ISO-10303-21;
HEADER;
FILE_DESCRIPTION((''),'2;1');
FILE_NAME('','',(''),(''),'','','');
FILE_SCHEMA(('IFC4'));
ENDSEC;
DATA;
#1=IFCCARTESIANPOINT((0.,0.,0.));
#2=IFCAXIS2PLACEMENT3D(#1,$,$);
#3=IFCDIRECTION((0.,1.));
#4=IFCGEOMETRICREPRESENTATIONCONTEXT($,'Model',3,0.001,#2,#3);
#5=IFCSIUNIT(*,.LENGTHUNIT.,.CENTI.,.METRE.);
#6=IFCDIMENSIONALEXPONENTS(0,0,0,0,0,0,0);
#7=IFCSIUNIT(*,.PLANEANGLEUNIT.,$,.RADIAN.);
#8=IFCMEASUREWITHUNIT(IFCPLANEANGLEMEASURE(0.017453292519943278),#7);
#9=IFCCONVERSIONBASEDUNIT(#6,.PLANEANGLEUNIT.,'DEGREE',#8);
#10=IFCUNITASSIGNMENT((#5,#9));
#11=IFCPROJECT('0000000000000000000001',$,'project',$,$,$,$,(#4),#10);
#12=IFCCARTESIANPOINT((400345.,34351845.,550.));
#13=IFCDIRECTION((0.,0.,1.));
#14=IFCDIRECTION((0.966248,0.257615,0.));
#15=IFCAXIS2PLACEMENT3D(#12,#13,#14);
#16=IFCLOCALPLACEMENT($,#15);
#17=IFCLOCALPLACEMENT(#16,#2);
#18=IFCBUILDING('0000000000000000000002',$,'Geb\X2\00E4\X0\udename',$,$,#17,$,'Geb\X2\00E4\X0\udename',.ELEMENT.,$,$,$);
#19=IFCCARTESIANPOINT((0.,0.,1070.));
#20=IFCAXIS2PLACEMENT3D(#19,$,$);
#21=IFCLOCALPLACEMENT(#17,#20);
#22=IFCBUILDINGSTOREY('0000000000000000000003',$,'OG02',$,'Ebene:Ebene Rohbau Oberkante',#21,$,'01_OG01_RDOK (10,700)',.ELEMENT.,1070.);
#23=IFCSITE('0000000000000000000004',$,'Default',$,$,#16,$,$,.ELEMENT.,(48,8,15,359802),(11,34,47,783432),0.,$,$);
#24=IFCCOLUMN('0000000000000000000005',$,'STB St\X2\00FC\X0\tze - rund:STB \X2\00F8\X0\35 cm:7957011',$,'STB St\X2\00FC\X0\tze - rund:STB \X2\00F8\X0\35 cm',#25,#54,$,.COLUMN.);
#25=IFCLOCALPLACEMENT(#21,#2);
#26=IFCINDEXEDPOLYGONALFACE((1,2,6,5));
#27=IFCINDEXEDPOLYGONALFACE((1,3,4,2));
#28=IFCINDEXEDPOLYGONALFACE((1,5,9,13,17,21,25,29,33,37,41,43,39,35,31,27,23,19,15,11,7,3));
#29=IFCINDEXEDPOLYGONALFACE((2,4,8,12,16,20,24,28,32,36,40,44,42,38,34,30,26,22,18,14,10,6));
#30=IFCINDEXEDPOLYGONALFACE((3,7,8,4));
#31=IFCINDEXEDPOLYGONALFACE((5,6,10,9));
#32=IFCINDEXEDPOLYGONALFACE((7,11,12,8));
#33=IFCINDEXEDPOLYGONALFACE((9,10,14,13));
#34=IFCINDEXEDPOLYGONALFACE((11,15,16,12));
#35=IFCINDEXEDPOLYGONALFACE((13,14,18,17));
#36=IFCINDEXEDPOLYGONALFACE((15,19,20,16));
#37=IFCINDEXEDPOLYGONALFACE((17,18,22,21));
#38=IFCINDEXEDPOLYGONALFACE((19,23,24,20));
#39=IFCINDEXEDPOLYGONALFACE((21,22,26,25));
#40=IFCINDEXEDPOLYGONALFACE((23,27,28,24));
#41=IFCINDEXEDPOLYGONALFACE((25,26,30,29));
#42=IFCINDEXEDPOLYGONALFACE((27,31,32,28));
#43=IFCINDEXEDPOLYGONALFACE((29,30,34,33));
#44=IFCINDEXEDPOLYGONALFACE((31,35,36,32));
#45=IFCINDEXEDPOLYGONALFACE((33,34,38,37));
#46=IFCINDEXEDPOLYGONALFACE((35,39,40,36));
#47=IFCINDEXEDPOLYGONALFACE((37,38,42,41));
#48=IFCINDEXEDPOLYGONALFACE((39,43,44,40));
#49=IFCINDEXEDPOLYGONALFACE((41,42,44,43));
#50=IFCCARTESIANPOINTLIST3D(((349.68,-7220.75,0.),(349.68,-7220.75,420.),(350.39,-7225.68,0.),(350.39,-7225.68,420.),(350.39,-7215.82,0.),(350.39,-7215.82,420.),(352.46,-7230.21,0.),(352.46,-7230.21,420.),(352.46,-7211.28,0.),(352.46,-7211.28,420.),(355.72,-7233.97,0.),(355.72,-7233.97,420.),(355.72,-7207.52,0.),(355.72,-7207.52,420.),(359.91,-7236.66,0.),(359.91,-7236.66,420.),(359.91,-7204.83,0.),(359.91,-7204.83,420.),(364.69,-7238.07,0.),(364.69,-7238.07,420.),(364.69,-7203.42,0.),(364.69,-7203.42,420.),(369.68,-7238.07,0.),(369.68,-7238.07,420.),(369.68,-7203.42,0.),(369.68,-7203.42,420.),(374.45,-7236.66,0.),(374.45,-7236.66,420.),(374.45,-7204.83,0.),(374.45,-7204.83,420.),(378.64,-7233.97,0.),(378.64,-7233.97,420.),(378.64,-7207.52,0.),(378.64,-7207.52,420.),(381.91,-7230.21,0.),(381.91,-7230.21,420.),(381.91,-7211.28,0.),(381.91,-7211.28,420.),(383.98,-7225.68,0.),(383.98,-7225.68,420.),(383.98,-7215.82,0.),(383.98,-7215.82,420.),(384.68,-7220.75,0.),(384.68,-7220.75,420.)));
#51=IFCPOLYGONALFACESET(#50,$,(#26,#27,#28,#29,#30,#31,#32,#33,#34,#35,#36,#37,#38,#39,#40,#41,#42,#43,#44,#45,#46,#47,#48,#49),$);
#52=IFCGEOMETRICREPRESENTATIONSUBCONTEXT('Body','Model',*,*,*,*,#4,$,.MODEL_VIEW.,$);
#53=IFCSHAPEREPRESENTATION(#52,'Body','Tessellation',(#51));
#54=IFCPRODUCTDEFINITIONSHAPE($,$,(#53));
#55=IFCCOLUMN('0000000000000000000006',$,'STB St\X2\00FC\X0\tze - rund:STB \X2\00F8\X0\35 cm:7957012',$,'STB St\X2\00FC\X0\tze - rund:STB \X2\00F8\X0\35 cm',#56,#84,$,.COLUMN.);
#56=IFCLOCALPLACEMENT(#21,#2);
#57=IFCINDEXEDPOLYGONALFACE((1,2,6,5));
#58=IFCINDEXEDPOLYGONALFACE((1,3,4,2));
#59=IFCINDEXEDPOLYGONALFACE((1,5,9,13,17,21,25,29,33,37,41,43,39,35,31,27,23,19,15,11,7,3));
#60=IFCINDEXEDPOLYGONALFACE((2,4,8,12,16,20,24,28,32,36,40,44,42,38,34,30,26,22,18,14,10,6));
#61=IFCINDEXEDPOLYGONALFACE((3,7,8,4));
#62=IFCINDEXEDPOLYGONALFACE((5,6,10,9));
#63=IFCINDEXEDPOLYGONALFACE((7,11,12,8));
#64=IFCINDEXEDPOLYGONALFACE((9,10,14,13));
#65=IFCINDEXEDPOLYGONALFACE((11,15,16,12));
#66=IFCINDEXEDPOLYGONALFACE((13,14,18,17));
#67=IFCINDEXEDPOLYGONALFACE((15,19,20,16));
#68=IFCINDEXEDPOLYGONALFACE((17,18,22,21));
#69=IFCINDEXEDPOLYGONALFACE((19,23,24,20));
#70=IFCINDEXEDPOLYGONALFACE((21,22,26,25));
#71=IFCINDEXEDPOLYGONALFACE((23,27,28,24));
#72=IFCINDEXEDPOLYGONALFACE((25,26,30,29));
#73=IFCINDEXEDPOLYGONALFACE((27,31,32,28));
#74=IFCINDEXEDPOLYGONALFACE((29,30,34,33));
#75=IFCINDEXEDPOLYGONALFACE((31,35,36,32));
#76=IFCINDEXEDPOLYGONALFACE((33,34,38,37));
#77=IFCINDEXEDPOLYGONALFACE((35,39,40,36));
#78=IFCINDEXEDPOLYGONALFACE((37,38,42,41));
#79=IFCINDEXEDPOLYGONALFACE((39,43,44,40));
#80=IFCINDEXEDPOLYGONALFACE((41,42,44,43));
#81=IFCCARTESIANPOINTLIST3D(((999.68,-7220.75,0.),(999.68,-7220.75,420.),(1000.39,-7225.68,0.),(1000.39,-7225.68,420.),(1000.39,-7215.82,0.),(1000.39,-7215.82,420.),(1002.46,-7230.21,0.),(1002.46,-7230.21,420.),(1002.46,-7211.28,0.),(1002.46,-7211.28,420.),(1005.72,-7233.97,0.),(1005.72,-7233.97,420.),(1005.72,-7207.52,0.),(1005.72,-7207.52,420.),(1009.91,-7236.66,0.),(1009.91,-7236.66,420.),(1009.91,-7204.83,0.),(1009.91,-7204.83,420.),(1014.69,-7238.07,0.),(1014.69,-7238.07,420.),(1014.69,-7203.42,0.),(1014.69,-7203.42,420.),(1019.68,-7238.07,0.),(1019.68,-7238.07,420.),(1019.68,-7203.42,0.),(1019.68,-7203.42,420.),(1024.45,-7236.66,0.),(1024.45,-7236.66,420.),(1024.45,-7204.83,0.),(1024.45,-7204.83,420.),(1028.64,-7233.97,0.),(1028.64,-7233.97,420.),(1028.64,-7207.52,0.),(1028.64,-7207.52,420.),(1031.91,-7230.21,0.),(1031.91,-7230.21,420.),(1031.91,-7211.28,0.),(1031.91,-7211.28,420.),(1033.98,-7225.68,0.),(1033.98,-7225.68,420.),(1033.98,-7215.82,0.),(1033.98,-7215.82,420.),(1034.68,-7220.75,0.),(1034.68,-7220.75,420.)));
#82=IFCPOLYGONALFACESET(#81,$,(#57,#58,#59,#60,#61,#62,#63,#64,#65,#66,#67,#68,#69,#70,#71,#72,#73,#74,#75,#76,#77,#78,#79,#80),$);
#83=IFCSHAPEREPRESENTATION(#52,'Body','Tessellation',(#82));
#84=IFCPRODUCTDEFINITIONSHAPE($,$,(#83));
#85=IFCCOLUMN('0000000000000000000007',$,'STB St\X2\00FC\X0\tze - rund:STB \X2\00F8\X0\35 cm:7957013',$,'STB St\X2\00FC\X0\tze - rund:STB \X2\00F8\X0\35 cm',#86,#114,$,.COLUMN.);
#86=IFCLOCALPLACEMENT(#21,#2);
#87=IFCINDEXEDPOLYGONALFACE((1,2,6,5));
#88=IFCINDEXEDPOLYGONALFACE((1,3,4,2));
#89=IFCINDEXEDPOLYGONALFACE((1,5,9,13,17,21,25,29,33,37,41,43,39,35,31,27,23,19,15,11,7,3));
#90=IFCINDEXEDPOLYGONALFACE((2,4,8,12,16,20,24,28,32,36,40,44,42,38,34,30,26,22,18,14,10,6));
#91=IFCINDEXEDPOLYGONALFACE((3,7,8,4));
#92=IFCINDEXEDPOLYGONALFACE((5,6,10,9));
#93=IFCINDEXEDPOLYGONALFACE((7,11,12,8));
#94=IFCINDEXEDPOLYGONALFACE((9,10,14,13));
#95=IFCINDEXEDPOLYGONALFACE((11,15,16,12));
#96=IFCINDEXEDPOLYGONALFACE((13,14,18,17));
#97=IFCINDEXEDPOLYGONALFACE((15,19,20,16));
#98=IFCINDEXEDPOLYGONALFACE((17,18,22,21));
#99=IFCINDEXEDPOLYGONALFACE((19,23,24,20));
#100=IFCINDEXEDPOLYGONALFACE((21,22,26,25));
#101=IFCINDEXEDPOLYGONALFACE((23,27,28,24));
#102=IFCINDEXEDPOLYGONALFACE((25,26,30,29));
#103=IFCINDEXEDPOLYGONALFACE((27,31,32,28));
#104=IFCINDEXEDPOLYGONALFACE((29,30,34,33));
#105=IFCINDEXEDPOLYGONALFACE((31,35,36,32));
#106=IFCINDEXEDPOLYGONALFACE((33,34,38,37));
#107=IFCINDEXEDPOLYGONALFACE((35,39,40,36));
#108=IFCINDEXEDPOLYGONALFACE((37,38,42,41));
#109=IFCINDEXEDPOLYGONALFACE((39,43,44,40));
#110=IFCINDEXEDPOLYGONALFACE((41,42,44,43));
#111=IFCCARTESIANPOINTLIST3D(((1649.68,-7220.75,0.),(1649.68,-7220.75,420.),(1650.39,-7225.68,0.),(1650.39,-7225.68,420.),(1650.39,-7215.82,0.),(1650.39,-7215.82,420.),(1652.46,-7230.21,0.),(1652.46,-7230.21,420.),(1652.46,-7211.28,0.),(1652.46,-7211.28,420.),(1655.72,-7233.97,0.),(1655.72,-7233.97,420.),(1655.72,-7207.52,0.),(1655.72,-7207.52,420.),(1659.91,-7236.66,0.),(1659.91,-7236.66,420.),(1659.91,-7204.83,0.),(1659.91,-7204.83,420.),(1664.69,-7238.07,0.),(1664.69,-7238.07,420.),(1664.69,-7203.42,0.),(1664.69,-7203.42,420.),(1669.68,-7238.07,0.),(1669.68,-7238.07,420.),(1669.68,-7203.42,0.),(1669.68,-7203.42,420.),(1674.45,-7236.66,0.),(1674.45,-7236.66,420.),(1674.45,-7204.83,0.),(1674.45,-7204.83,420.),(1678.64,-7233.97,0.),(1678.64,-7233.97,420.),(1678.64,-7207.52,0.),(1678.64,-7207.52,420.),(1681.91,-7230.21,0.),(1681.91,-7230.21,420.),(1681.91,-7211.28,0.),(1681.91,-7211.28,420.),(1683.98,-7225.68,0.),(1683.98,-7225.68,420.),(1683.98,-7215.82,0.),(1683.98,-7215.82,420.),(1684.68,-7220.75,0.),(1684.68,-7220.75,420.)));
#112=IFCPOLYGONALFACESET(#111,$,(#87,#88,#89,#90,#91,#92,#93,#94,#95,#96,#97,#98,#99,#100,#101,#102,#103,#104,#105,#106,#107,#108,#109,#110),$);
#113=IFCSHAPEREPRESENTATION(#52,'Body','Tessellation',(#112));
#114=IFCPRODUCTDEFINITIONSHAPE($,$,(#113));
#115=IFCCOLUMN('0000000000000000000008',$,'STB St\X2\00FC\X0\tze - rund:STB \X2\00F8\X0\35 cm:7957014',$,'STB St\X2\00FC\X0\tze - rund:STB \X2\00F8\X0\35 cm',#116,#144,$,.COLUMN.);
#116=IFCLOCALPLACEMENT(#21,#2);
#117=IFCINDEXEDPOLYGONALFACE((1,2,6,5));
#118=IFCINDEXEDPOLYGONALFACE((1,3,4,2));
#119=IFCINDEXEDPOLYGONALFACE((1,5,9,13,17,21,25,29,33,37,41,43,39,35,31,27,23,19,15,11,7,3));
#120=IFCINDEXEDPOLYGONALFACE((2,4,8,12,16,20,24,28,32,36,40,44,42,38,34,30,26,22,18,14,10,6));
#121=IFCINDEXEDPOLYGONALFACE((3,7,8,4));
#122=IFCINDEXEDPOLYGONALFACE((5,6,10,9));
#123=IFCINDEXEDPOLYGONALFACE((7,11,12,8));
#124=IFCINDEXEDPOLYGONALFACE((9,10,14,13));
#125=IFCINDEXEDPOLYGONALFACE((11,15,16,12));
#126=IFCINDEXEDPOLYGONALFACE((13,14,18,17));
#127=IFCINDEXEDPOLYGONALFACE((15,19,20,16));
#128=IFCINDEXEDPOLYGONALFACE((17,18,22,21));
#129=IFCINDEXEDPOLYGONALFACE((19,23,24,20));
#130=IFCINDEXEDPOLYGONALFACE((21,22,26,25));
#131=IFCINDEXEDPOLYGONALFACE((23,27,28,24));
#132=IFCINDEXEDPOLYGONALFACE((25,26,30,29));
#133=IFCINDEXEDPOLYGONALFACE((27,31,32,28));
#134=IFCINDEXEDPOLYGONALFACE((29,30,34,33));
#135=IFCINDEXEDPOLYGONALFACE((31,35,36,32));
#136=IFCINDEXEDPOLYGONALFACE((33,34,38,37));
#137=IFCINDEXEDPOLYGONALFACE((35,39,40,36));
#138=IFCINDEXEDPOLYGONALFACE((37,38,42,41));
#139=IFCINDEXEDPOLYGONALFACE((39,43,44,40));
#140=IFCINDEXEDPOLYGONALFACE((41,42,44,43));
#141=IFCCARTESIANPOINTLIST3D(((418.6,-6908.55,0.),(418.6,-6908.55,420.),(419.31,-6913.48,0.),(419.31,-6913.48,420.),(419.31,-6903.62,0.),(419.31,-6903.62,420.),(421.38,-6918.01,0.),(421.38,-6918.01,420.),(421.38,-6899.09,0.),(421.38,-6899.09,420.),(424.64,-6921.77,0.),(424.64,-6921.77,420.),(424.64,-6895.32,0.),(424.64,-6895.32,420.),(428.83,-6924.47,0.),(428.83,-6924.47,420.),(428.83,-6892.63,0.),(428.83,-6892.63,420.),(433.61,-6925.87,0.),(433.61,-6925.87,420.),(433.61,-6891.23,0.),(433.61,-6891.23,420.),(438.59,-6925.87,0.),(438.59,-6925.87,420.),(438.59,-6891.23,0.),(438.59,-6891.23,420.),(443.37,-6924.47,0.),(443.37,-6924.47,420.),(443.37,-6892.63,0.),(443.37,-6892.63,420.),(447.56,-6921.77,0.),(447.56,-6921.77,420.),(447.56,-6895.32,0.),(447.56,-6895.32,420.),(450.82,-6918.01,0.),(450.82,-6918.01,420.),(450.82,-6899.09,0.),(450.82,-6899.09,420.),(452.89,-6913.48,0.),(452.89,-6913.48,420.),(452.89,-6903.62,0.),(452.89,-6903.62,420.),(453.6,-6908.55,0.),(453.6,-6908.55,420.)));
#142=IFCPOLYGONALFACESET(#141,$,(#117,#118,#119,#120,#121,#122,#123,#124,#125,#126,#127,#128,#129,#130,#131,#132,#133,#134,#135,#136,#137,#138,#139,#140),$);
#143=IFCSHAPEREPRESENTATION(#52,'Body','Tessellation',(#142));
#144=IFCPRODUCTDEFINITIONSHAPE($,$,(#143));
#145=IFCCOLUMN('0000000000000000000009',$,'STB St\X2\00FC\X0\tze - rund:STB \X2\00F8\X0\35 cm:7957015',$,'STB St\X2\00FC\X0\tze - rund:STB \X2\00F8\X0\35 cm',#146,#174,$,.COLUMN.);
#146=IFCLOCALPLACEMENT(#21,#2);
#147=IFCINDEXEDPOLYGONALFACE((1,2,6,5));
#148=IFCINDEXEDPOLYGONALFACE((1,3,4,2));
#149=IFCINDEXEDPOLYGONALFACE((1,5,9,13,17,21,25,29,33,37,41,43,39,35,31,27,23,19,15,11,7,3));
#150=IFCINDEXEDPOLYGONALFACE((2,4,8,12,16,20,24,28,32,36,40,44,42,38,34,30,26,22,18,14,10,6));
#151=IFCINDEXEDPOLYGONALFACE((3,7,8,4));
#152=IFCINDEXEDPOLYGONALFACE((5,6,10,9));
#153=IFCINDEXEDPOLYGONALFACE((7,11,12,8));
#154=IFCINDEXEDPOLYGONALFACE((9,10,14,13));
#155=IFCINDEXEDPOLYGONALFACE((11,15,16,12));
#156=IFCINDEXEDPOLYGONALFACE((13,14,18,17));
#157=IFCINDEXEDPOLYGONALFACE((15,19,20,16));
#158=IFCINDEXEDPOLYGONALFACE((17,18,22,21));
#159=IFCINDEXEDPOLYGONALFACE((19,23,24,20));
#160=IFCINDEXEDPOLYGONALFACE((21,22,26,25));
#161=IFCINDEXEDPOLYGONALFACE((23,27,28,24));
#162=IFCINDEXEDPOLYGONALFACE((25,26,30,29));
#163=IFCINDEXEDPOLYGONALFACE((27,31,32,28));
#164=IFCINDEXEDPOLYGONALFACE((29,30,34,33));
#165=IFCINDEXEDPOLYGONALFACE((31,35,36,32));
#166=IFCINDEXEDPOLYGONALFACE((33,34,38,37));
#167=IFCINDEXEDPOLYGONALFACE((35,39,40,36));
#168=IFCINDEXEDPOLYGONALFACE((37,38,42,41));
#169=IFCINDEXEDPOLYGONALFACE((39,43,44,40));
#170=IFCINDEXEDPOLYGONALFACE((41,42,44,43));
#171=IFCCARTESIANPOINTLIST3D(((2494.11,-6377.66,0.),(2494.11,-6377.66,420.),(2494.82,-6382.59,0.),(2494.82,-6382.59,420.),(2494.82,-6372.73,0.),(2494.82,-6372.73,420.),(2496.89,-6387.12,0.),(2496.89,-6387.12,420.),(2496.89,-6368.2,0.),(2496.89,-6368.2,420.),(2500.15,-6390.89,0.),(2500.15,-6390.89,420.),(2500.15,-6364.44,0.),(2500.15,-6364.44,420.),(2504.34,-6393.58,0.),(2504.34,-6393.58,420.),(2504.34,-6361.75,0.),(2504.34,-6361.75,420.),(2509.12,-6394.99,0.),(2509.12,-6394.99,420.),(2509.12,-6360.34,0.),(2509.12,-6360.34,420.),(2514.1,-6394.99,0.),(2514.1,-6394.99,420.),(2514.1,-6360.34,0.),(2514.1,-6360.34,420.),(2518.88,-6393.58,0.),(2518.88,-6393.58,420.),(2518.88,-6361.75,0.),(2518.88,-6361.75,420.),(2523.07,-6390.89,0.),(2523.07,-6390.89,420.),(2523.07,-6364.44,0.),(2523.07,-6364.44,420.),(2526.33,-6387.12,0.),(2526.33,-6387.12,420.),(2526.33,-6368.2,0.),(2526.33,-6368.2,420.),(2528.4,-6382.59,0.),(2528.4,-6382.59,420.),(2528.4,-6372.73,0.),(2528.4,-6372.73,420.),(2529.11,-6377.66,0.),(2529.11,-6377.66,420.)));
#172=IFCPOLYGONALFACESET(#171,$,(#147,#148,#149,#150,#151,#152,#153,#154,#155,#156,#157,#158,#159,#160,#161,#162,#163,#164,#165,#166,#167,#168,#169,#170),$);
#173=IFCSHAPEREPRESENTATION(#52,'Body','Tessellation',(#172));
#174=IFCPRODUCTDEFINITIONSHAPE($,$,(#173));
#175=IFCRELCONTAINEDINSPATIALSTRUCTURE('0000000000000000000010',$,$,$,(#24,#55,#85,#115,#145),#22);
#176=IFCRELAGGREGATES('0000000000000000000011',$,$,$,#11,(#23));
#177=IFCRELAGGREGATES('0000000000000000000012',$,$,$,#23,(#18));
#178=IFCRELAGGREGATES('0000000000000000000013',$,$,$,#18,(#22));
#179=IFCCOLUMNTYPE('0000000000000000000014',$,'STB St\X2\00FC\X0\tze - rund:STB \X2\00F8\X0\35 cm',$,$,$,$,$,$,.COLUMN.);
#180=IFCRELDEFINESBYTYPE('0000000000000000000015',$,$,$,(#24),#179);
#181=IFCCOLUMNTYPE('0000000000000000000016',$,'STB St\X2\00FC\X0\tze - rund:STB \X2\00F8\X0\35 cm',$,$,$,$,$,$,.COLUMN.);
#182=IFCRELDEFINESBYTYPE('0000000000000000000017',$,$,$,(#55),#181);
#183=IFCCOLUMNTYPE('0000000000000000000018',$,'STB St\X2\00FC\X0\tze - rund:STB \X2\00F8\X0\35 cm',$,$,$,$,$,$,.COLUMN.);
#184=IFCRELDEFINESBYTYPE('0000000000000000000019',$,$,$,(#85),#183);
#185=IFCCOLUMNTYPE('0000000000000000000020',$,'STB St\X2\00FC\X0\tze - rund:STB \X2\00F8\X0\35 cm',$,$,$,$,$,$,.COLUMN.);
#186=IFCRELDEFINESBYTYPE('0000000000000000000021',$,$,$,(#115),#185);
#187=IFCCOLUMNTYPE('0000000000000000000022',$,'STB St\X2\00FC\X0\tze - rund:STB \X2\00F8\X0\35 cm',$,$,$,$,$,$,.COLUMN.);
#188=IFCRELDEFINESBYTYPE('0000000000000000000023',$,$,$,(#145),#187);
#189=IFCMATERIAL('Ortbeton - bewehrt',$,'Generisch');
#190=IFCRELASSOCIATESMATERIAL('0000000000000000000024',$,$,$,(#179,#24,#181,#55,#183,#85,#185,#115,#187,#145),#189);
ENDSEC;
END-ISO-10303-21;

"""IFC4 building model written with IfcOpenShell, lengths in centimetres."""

from ifc_helpers import new_model, entity, si_unit, converted_unit, direction, frame, origin, place, context, subcontext, project, spatial, arc, indexed_curve, outline, extrude, source, transform, mapped, material, type_object, type_shapes, element, save


model = new_model("IFC4")

# Units and contexts
model_context = context("Model", 3, precision=0.001, world=origin(), true_north=direction((0.0, 1.0)))
body_context = subcontext(model_context, "Body", "Model", "MODEL_VIEW")
ifc_project = project(units=[si_unit("LENGTHUNIT", "METRE", prefix="CENTI"), converted_unit("PLANEANGLEUNIT", "DEGREE", entity("IfcPlaneAngleMeasure", 0.017453292519943278), si_unit("PLANEANGLEUNIT", "RADIAN"), dimensions=[0, 0, 0, 0, 0, 0, 0])], contexts=[model_context])

# Site, building, storey
site_placement = place(None, frame((400345.0, 34351845.0, 550.0), z_axis=(0.0, 0.0, 1.0), x_axis=(0.966248, 0.257615, 0.0)))
site = spatial("IfcSite", under=ifc_project, at=site_placement, Name="Default", CompositionType="ELEMENT", RefLatitude=(48, 8, 15, 359802), RefLongitude=(11, 34, 47, 783432), RefElevation=0.0)
building_placement = place(site_placement, origin())
building = spatial("IfcBuilding", under=site, at=building_placement, Name="Gebäudename", LongName="Gebäudename", CompositionType="ELEMENT")
storey_placement = place(building_placement, frame((0.0, 0.0, 1070.0)))
storey = spatial("IfcBuildingStorey", under=building, at=storey_placement, Name="OG02", ObjectType="Ebene:Ebene Rohbau Oberkante", LongName="01_OG01_RDOK (10,700)", CompositionType="ELEMENT", Elevation=1070.0)

# Columns
ifc_material = material(Name="Ortbeton - bewehrt", Category="Generisch")
column_type_1 = type_object("IfcColumnType", Name="STB Stütze - rund:STB ø35 cm", PredefinedType="COLUMN", material=ifc_material)
shared_shape_1 = source(origin(), body_context, "Body", "SweptSolid", [
    extrude(outline(indexed_curve([(-17.5, 0.0), (0.0, -17.5), (17.5, 0.0), (0.0, 17.5)], segments=[arc(1, 2, 3), arc(3, 4, 1)], self_intersect=False)), frame((367.18, -7220.75, 1070.0)), (0.0, 0.0, 1.0), 420.0),
])
type_shapes(column_type_1, [shared_shape_1])
column_1_placement = place(storey_placement, frame((0.0, 0.0, -1070.0)))
element("IfcColumn", 1, at=column_1_placement, inside=storey, type_object=column_type_1, material=ifc_material, Name="STB Stütze - rund:STB ø35 cm:7957011", ObjectType="STB Stütze - rund:STB ø35 cm", PredefinedType="COLUMN", context=body_context, shape_type="MappedRepresentation", body=[
    mapped(shared_shape_1, transform((0.0, 0.0, 0.0), scale=1.0)),
])
column_type_2 = type_object("IfcColumnType", Name="STB Stütze - rund:STB ø35 cm", PredefinedType="COLUMN", material=ifc_material)
shared_shape_2 = source(origin(), body_context, "Body", "SweptSolid", [
    extrude(outline(indexed_curve([(-17.5, 0.0), (0.0, -17.5), (17.5, 0.0), (0.0, 17.5)], segments=[arc(1, 2, 3), arc(3, 4, 1)], self_intersect=False)), frame((1017.18, -7220.75, 1070.0)), (0.0, 0.0, 1.0), 420.0),
])
type_shapes(column_type_2, [shared_shape_2])
column_2_placement = place(storey_placement, frame((0.0, 0.0, -1070.0)))
element("IfcColumn", 2, at=column_2_placement, inside=storey, type_object=column_type_2, material=ifc_material, Name="STB Stütze - rund:STB ø35 cm:7957012", ObjectType="STB Stütze - rund:STB ø35 cm", PredefinedType="COLUMN", context=body_context, shape_type="MappedRepresentation", body=[
    mapped(shared_shape_2, transform((0.0, 0.0, 0.0), scale=1.0)),
])
column_type_3 = type_object("IfcColumnType", Name="STB Stütze - rund:STB ø35 cm", PredefinedType="COLUMN", material=ifc_material)
shared_shape_3 = source(origin(), body_context, "Body", "SweptSolid", [
    extrude(outline(indexed_curve([(-17.5, 0.0), (0.0, -17.5), (17.5, 0.0), (0.0, 17.5)], segments=[arc(1, 2, 3), arc(3, 4, 1)], self_intersect=False)), frame((1667.18, -7220.75, 1070.0)), (0.0, 0.0, 1.0), 420.0),
])
type_shapes(column_type_3, [shared_shape_3])
column_3_placement = place(storey_placement, frame((0.0, 0.0, -1070.0)))
element("IfcColumn", 3, at=column_3_placement, inside=storey, type_object=column_type_3, material=ifc_material, Name="STB Stütze - rund:STB ø35 cm:7957013", ObjectType="STB Stütze - rund:STB ø35 cm", PredefinedType="COLUMN", context=body_context, shape_type="MappedRepresentation", body=[
    mapped(shared_shape_3, transform((0.0, 0.0, 0.0), scale=1.0)),
])
column_type_4 = type_object("IfcColumnType", Name="STB Stütze - rund:STB ø35 cm", PredefinedType="COLUMN", material=ifc_material)
shared_shape_4 = source(origin(), body_context, "Body", "SweptSolid", [
    extrude(outline(indexed_curve([(-17.5, 0.0), (0.0, -17.5), (17.5, 0.0), (0.0, 17.5)], segments=[arc(1, 2, 3), arc(3, 4, 1)], self_intersect=False)), frame((436.1, -6908.55, 1070.0)), (0.0, 0.0, 1.0), 420.0),
])
type_shapes(column_type_4, [shared_shape_4])
column_4_placement = place(storey_placement, frame((0.0, 0.0, -1070.0)))
element("IfcColumn", 4, at=column_4_placement, inside=storey, type_object=column_type_4, material=ifc_material, Name="STB Stütze - rund:STB ø35 cm:7957014", ObjectType="STB Stütze - rund:STB ø35 cm", PredefinedType="COLUMN", context=body_context, shape_type="MappedRepresentation", body=[
    mapped(shared_shape_4, transform((0.0, 0.0, 0.0), scale=1.0)),
])
column_type_5 = type_object("IfcColumnType", Name="STB Stütze - rund:STB ø35 cm", PredefinedType="COLUMN", material=ifc_material)
shared_shape_5 = source(origin(), body_context, "Body", "SweptSolid", [
    extrude(outline(indexed_curve([(-17.5, 0.0), (0.0, -17.5), (17.5, 0.0), (0.0, 17.5)], segments=[arc(1, 2, 3), arc(3, 4, 1)], self_intersect=False)), frame((2511.61, -6377.66, 1070.0)), (0.0, 0.0, 1.0), 420.0),
])
type_shapes(column_type_5, [shared_shape_5])
column_5_placement = place(storey_placement, frame((0.0, 0.0, -1070.0)))
element("IfcColumn", 5, at=column_5_placement, inside=storey, type_object=column_type_5, material=ifc_material, Name="STB Stütze - rund:STB ø35 cm:7957015", ObjectType="STB Stütze - rund:STB ø35 cm", PredefinedType="COLUMN", context=body_context, shape_type="MappedRepresentation", body=[
    mapped(shared_shape_5, transform((0.0, 0.0, 0.0), scale=1.0)),
])

save(model, "model.ifc")
